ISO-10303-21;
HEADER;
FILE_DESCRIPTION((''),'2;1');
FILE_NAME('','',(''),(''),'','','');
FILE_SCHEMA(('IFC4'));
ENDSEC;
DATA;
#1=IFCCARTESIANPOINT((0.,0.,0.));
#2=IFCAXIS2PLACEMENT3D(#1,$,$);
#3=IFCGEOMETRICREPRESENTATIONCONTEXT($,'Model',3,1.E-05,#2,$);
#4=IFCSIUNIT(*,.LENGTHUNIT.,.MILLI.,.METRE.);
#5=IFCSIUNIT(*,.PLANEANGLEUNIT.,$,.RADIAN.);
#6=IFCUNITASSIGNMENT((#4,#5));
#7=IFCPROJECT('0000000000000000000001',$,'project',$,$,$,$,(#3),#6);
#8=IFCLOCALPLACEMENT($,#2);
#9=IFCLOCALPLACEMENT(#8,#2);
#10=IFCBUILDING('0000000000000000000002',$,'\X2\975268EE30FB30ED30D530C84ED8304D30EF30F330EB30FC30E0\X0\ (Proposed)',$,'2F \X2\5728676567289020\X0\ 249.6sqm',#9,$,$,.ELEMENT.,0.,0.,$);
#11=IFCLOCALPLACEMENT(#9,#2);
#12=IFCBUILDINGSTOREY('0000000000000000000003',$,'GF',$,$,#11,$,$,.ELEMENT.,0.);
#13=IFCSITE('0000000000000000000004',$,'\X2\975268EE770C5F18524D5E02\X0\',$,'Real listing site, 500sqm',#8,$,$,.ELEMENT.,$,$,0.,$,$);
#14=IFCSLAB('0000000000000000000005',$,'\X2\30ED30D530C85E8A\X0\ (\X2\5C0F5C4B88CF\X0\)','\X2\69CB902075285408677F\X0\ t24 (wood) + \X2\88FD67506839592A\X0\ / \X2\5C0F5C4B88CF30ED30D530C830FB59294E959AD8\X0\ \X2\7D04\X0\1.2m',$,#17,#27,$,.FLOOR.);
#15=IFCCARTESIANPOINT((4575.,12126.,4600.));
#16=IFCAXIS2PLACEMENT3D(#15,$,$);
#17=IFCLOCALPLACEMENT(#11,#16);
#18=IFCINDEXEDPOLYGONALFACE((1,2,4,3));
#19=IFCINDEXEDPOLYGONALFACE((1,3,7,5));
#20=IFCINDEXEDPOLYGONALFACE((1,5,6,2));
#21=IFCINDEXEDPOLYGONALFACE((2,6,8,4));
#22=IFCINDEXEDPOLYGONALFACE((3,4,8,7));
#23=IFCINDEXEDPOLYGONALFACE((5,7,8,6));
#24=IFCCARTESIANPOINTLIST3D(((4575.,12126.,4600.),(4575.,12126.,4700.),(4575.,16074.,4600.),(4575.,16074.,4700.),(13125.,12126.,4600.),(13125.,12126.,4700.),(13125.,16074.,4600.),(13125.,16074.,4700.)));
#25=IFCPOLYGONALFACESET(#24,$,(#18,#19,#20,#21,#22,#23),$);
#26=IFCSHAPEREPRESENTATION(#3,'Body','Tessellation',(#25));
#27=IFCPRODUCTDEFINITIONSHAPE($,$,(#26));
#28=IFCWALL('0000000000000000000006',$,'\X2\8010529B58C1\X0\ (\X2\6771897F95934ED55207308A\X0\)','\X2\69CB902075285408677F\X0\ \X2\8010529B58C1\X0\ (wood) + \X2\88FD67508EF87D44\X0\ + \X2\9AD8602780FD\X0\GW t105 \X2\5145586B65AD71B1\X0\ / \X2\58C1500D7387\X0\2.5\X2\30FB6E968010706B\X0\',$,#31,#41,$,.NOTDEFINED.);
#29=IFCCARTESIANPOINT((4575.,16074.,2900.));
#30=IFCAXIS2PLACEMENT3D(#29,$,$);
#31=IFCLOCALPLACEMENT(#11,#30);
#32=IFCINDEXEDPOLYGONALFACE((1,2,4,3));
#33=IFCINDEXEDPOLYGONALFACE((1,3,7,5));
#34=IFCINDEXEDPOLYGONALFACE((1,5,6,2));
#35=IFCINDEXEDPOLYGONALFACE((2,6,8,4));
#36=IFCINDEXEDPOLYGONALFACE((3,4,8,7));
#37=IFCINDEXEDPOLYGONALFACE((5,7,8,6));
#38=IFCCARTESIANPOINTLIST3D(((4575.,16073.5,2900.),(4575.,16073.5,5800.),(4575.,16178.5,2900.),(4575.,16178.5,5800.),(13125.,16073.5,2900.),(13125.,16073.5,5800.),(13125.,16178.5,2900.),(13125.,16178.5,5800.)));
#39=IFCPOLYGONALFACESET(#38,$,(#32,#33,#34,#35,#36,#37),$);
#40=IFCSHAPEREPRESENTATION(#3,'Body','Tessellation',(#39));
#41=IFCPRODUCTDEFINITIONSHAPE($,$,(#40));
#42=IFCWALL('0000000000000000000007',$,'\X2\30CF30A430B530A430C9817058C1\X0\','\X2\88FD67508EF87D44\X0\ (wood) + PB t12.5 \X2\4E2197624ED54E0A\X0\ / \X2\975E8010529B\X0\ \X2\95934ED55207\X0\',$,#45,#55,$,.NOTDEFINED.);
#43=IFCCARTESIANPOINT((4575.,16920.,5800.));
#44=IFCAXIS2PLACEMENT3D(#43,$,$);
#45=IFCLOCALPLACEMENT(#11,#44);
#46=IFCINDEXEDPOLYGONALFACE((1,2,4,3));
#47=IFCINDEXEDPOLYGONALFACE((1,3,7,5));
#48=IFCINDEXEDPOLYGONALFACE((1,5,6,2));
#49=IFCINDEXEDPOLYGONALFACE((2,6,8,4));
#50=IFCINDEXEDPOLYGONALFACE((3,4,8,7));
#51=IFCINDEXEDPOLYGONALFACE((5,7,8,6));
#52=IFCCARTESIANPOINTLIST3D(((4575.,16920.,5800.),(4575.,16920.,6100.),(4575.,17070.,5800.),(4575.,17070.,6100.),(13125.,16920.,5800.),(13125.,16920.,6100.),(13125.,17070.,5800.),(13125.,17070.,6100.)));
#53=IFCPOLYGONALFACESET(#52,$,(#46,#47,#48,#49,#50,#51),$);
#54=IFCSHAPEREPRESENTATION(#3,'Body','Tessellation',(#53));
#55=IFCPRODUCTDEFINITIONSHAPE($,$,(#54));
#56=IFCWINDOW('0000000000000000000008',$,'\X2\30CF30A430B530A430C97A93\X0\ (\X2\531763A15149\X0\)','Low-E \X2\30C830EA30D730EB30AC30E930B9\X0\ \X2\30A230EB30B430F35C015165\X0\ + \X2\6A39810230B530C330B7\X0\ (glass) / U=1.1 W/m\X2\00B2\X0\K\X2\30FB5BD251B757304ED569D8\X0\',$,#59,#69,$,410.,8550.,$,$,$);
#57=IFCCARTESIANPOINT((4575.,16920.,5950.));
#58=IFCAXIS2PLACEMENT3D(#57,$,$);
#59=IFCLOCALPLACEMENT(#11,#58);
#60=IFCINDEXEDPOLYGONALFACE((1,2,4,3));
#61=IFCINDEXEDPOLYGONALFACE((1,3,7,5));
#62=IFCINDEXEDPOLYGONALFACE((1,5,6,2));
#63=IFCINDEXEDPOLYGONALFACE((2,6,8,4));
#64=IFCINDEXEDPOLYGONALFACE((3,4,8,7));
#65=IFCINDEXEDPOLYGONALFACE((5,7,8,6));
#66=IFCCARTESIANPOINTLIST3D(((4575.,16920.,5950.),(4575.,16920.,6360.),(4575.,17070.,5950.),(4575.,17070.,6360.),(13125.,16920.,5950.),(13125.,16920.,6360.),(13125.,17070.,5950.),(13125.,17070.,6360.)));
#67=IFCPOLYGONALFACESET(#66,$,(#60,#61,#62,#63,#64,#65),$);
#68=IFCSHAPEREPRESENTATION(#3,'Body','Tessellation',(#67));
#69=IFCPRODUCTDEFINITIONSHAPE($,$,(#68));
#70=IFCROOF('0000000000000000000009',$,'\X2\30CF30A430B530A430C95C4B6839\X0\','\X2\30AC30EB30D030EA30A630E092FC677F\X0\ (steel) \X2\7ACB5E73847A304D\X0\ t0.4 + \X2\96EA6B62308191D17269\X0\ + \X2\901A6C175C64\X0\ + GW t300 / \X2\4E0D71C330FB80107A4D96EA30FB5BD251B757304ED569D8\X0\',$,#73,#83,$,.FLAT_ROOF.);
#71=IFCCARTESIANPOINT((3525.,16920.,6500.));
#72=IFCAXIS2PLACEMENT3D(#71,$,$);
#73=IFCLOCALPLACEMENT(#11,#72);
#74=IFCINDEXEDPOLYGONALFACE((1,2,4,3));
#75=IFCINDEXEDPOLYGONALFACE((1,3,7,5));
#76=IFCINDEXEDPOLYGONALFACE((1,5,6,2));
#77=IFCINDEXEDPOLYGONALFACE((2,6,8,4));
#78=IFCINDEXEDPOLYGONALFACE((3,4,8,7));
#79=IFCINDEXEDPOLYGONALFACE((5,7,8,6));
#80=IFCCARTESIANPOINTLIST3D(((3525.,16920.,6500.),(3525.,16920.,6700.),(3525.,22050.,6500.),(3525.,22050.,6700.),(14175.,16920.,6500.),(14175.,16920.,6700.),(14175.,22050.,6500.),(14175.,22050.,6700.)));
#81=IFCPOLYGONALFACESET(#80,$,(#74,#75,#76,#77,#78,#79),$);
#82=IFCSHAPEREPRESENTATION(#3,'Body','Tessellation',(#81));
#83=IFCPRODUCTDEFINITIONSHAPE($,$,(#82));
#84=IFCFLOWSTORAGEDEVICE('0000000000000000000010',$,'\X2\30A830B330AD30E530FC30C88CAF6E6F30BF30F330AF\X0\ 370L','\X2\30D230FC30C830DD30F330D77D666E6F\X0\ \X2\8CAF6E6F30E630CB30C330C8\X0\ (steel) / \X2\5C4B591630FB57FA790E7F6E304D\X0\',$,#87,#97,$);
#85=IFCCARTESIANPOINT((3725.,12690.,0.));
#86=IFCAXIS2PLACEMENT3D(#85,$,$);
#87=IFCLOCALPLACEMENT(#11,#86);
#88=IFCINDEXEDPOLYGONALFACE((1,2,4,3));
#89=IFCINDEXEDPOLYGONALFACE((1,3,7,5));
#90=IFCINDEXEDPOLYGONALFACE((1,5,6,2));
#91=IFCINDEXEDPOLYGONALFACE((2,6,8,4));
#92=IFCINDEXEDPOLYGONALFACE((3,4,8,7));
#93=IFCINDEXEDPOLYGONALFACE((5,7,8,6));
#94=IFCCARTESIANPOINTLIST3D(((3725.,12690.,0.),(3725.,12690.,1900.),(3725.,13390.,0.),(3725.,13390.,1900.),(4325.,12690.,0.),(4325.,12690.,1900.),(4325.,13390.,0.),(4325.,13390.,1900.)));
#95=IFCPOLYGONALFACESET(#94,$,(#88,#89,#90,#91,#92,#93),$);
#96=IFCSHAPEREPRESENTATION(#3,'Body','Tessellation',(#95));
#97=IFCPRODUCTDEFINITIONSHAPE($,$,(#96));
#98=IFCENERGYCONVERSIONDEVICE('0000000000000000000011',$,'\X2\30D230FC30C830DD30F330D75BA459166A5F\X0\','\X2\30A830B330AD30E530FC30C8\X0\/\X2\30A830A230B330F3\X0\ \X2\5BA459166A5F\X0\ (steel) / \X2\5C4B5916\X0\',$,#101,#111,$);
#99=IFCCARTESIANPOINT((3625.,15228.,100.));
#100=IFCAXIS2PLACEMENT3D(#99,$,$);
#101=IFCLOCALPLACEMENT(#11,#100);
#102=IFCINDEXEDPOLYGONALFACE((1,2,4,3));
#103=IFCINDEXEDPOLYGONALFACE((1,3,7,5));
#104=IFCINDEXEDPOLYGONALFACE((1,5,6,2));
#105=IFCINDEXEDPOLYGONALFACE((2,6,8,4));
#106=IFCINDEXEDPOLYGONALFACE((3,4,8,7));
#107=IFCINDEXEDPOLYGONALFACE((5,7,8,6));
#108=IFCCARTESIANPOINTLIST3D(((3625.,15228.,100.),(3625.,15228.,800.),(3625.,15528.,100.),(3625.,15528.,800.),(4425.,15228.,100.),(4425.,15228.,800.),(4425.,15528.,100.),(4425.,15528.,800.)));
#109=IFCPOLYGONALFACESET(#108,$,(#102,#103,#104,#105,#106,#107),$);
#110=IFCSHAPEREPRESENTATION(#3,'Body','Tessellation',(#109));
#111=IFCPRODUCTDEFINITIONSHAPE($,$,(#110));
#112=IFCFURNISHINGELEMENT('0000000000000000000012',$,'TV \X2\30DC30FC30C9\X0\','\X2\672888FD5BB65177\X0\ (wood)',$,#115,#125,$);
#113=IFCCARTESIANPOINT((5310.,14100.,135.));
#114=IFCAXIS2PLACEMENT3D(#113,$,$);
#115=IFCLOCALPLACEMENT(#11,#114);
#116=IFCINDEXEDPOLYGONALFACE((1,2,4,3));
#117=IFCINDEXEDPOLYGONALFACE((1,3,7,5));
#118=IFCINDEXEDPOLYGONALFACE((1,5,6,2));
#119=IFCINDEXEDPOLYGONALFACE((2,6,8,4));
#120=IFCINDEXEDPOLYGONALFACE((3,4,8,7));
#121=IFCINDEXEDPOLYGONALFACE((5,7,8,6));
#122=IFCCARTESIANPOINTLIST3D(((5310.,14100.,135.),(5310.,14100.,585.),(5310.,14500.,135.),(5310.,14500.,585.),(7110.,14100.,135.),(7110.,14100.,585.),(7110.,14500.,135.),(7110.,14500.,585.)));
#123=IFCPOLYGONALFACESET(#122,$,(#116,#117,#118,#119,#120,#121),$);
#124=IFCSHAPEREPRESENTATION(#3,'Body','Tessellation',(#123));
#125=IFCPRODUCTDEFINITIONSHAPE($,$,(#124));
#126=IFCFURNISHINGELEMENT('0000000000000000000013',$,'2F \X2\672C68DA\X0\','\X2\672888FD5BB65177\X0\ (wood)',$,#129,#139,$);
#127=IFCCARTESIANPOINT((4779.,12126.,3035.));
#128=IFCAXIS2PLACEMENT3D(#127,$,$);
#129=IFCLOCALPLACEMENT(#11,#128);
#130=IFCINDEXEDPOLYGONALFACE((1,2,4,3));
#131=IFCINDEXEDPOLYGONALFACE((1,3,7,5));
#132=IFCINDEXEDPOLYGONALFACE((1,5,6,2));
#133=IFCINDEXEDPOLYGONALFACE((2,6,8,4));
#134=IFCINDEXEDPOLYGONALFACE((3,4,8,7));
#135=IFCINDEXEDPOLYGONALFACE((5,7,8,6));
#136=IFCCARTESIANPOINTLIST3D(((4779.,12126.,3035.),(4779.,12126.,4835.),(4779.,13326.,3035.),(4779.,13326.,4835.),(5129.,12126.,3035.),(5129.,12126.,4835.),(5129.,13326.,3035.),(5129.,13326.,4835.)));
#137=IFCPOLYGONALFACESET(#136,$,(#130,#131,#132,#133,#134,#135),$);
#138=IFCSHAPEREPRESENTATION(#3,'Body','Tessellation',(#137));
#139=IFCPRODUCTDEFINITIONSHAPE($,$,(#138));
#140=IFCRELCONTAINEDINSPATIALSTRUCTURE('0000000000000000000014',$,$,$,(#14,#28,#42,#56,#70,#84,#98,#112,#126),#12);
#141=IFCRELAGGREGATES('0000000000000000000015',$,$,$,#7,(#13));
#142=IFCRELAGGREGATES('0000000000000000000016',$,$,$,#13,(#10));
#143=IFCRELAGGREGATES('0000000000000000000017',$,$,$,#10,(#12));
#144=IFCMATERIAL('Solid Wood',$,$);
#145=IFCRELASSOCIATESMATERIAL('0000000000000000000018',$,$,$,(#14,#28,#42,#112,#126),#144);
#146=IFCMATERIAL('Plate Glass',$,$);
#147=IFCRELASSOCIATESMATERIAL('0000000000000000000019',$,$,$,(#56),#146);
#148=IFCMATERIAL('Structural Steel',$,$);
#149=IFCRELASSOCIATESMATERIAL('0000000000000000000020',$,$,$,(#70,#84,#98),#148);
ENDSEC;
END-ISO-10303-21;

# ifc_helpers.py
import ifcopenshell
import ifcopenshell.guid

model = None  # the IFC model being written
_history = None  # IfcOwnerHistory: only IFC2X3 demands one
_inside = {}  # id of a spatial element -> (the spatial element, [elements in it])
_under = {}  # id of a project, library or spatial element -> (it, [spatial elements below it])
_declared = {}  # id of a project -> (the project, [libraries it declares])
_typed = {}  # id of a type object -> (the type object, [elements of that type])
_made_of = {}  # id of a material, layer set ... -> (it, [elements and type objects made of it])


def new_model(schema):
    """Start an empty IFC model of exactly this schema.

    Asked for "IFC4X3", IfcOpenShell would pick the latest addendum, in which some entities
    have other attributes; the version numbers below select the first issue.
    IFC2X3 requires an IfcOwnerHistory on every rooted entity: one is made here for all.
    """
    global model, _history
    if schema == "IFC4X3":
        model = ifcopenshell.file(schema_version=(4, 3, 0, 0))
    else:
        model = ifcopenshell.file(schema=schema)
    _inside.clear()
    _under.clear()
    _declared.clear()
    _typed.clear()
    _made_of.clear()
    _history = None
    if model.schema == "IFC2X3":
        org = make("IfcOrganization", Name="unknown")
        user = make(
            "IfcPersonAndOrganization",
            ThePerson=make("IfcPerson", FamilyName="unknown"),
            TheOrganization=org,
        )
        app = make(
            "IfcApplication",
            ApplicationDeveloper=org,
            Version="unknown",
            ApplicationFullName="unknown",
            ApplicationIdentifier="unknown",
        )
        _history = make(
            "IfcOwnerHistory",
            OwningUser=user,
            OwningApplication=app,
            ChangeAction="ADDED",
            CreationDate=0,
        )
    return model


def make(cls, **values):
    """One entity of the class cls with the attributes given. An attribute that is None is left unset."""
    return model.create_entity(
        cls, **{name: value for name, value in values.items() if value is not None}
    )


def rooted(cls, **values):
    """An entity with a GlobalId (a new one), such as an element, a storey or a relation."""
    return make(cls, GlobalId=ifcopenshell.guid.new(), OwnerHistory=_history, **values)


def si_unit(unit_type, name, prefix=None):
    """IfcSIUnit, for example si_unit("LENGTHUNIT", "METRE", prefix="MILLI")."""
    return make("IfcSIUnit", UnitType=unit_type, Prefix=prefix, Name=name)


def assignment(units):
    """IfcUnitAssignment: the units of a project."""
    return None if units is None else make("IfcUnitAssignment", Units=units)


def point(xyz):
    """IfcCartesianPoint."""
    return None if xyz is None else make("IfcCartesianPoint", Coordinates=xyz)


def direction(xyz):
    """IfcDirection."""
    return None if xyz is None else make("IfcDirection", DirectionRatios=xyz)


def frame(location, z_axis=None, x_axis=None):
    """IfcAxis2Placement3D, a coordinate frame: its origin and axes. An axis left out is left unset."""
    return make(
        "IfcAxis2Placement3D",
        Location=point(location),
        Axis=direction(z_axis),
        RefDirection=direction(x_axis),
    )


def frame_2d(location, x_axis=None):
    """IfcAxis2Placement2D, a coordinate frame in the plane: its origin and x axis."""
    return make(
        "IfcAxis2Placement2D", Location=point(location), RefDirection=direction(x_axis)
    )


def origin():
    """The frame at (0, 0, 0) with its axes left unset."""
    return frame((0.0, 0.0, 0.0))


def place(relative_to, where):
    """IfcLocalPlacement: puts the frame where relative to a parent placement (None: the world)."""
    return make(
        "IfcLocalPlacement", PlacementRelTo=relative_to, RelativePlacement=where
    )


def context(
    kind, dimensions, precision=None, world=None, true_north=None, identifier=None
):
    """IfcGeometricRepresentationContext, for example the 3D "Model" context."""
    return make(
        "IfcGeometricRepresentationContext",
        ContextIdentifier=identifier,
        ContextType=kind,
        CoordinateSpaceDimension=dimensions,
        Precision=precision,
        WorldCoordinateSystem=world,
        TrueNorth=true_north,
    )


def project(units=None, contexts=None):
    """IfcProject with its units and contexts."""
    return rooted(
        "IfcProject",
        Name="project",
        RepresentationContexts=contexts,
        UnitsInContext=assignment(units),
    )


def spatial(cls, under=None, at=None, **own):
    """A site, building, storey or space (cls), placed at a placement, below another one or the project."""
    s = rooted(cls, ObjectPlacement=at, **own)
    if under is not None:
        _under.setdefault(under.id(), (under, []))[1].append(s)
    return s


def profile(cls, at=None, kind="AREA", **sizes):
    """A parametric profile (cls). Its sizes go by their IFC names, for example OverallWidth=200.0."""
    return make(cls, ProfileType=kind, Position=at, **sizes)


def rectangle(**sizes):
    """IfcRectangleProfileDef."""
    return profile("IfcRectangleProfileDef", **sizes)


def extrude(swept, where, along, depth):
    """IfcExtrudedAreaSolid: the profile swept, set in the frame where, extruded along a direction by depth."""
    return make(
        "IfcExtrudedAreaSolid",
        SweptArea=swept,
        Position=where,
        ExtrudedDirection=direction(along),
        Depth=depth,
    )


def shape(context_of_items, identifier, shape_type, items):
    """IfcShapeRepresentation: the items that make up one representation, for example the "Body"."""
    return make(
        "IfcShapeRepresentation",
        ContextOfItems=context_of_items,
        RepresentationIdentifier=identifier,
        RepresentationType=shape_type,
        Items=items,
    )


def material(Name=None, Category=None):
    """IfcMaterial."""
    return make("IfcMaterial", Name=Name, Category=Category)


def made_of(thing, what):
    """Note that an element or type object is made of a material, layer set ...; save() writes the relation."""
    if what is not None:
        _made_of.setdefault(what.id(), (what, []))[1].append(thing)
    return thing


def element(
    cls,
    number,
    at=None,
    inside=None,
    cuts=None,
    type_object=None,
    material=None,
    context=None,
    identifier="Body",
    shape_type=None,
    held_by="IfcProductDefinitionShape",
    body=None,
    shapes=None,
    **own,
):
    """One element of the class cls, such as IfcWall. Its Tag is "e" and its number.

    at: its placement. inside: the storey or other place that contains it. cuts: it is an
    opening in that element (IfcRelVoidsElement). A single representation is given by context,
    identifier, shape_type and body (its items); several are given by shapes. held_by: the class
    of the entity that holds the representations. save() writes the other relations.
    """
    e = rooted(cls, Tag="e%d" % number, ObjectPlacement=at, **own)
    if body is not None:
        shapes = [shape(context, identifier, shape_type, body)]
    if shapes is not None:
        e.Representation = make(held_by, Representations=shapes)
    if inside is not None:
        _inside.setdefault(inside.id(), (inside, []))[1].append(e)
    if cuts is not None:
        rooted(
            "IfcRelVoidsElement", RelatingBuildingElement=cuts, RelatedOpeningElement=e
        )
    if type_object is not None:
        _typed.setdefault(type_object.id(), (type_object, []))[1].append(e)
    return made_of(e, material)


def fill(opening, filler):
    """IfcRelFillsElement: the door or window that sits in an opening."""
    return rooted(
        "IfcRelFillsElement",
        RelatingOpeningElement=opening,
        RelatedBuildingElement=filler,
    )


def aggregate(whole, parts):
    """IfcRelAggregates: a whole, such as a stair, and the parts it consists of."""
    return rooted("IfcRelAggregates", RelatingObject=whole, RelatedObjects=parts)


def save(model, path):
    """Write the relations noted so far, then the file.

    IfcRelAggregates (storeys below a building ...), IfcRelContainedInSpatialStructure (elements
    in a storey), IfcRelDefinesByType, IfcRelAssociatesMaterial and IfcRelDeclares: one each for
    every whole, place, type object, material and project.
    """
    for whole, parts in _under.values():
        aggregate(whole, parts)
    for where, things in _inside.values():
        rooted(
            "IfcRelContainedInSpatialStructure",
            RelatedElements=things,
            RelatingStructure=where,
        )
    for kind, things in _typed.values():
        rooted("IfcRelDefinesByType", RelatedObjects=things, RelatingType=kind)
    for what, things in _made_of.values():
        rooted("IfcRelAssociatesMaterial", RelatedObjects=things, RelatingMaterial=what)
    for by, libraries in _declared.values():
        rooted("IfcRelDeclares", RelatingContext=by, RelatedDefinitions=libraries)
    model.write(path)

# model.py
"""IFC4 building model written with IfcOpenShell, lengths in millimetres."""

from ifc_helpers import new_model, si_unit, frame, frame_2d, origin, place, context, project, spatial, rectangle, extrude, material, element, fill, save


model = new_model("IFC4")

# Units and contexts
model_context = context("Model", 3, precision=1e-05, world=origin())
ifc_project = project(units=[si_unit("LENGTHUNIT", "METRE", prefix="MILLI"), si_unit("PLANEANGLEUNIT", "RADIAN")], contexts=[model_context])

# Site, building, storey
site_placement = place(None, origin())
site = spatial("IfcSite", under=ifc_project, at=site_placement, Name="青森県弘前市", ObjectType="Real listing site, 500sqm", CompositionType="ELEMENT", RefElevation=0.0)
building_placement = place(site_placement, origin())
building = spatial("IfcBuilding", under=site, at=building_placement, Name="青森・ロフト付きワンルーム (Proposed)", ObjectType="2F 在来木造 249.6sqm", CompositionType="ELEMENT", ElevationOfRefHeight=0.0, ElevationOfTerrain=0.0)
storey_placement = place(building_placement, origin())
storey = spatial("IfcBuildingStorey", under=building, at=storey_placement, Name="GF", CompositionType="ELEMENT", Elevation=0.0)

# Shared definitions
ifc_material_1 = material(Name="Solid Wood")

# Slab
slab_placement = place(storey_placement, frame((4575.0, 12126.0, 4600.0)))
element("IfcSlab", 1, at=slab_placement, inside=storey, material=ifc_material_1, Name="ロフト床 (小屋裏)", Description="構造用合板 t24 (wood) + 製材根太 / 小屋裏ロフト・天井高 約1.2m", PredefinedType="FLOOR", context=model_context, shape_type="SweptSolid", body=[
    extrude(rectangle(XDim=8550.0, YDim=3948.0, at=frame_2d((4275.0, 1974.0))), frame((4575.0, 12126.0, 4600.0)), (0.0, 0.0, 1.0), 100.0),
])

# Wall
wall_1_placement = place(storey_placement, frame((4575.0, 16074.0, 2900.0)))
element("IfcWall", 2, at=wall_1_placement, inside=storey, material=ifc_material_1, Name="耐力壁 (東西間仕切り)", Description="構造用合板 耐力壁 (wood) + 製材軸組 + 高性能GW t105 充填断熱 / 壁倍率2.5・準耐火", PredefinedType="NOTDEFINED", context=model_context, shape_type="SweptSolid", body=[
    extrude(rectangle(XDim=8550.0, YDim=105.0, at=frame_2d((4275.0, 52.0))), frame((4575.0, 16074.0, 2900.0)), (0.0, 0.0, 1.0), 2900.0),
])

# Wall, opening, window
wall_2_placement = place(storey_placement, frame((4575.0, 16920.0, 5800.0)))
wall_2 = element("IfcWall", 3, at=wall_2_placement, inside=storey, material=ifc_material_1, Name="ハイサイド腰壁", Description="製材軸組 (wood) + PB t12.5 両面仕上 / 非耐力 間仕切", PredefinedType="NOTDEFINED", context=model_context, shape_type="SweptSolid", body=[
    extrude(rectangle(XDim=8550.0, YDim=150.0, at=frame_2d((4275.0, 75.0))), frame((4575.0, 16920.0, 5800.0)), (0.0, 0.0, 1.0), 700.0),
])
opening_1_placement = place(storey_placement, frame((4575.0, 16920.0, 5950.0)))
opening_1 = element("IfcOpeningElement", 4, at=opening_1_placement, cuts=wall_2, PredefinedType="NOTDEFINED", context=model_context, shape_type="SweptSolid", body=[
    extrude(rectangle(XDim=8550.0, YDim=150.0, at=frame_2d((4275.0, 75.0))), frame((4575.0, 16920.0, 5950.0)), (0.0, 0.0, 1.0), 410.0),
])
ifc_material_2 = material(Name="Plate Glass")
window_placement = place(storey_placement, frame((4575.0, 16920.0, 5950.0)))
window = element("IfcWindow", 5, at=window_placement, inside=storey, material=ifc_material_2, Name="ハイサイド窓 (北採光)", Description="Low-E トリプルガラス アルゴン封入 + 樹脂サッシ (glass) / U=1.1 W/m²K・寒冷地仕様", OverallHeight=410.0, OverallWidth=8550.0, context=model_context, shape_type="SweptSolid", body=[
    extrude(rectangle(XDim=8550.0, YDim=150.0, at=frame_2d((4275.0, 75.0))), frame((4575.0, 16920.0, 5950.0)), (0.0, 0.0, 1.0), 410.0),
])
fill(opening_1, window)

# Roof
ifc_material_3 = material(Name="Structural Steel")
roof_placement = place(storey_placement, frame((3525.0, 16920.0, 6500.0)))
element("IfcRoof", 6, at=roof_placement, inside=storey, material=ifc_material_3, Name="ハイサイド屋根", Description="ガルバリウム鋼板 (steel) 立平葺き t0.4 + 雪止め金物 + 通気層 + GW t300 / 不燃・耐積雪・寒冷地仕様", PredefinedType="FLAT_ROOF", context=model_context, shape_type="SweptSolid", body=[
    extrude(rectangle(XDim=10650.0, YDim=5130.0, at=frame_2d((5325.0, 2565.0))), frame((3525.0, 16920.0, 6500.0)), (0.0, 0.0, 1.0), 200.0),
])

# Flow storage device
flow_storage_device_placement = place(storey_placement, frame((3725.0, 12690.0, 0.0)))
element("IfcFlowStorageDevice", 7, at=flow_storage_device_placement, inside=storey, material=ifc_material_3, Name="エコキュート貯湯タンク 370L", Description="ヒートポンプ給湯 貯湯ユニット (steel) / 屋外・基礎置き", context=model_context, shape_type="SweptSolid", body=[
    extrude(rectangle(XDim=600.0, YDim=700.0, at=frame_2d((300.0, 350.0))), frame((3725.0, 12690.0, 0.0)), (0.0, 0.0, 1.0), 1900.0),
])

# Energy conversion device
energy_conversion_device_placement = place(storey_placement, frame((3625.0, 15228.0, 100.0)))
element("IfcEnergyConversionDevice", 8, at=energy_conversion_device_placement, inside=storey, material=ifc_material_3, Name="ヒートポンプ室外機", Description="エコキュート/エアコン 室外機 (steel) / 屋外", context=model_context, shape_type="SweptSolid", body=[
    extrude(rectangle(XDim=800.0, YDim=300.0, at=frame_2d((400.0, 150.0))), frame((3625.0, 15228.0, 100.0)), (0.0, 0.0, 1.0), 700.0),
])

# Furnishing elements
furnishing_1_placement = place(storey_placement, frame((5310.0, 14100.0, 135.0)))
element("IfcFurnishingElement", 9, at=furnishing_1_placement, inside=storey, material=ifc_material_1, Name="TV ボード", Description="木製家具 (wood)", context=model_context, shape_type="SweptSolid", body=[
    extrude(rectangle(XDim=1800.0, YDim=400.0, at=frame_2d((900.0, 200.0))), frame((5310.0, 14100.0, 135.0)), (0.0, 0.0, 1.0), 450.0),
])
furnishing_2_placement = place(storey_placement, frame((4779.0, 12126.0, 3035.0)))
element("IfcFurnishingElement", 10, at=furnishing_2_placement, inside=storey, material=ifc_material_1, Name="2F 本棚", Description="木製家具 (wood)", context=model_context, shape_type="SweptSolid", body=[
    extrude(rectangle(XDim=350.0, YDim=1200.0, at=frame_2d((175.0, 600.0))), frame((4779.0, 12126.0, 3035.0)), (0.0, 0.0, 1.0), 1800.0),
])

save(model, "model.ifc")
